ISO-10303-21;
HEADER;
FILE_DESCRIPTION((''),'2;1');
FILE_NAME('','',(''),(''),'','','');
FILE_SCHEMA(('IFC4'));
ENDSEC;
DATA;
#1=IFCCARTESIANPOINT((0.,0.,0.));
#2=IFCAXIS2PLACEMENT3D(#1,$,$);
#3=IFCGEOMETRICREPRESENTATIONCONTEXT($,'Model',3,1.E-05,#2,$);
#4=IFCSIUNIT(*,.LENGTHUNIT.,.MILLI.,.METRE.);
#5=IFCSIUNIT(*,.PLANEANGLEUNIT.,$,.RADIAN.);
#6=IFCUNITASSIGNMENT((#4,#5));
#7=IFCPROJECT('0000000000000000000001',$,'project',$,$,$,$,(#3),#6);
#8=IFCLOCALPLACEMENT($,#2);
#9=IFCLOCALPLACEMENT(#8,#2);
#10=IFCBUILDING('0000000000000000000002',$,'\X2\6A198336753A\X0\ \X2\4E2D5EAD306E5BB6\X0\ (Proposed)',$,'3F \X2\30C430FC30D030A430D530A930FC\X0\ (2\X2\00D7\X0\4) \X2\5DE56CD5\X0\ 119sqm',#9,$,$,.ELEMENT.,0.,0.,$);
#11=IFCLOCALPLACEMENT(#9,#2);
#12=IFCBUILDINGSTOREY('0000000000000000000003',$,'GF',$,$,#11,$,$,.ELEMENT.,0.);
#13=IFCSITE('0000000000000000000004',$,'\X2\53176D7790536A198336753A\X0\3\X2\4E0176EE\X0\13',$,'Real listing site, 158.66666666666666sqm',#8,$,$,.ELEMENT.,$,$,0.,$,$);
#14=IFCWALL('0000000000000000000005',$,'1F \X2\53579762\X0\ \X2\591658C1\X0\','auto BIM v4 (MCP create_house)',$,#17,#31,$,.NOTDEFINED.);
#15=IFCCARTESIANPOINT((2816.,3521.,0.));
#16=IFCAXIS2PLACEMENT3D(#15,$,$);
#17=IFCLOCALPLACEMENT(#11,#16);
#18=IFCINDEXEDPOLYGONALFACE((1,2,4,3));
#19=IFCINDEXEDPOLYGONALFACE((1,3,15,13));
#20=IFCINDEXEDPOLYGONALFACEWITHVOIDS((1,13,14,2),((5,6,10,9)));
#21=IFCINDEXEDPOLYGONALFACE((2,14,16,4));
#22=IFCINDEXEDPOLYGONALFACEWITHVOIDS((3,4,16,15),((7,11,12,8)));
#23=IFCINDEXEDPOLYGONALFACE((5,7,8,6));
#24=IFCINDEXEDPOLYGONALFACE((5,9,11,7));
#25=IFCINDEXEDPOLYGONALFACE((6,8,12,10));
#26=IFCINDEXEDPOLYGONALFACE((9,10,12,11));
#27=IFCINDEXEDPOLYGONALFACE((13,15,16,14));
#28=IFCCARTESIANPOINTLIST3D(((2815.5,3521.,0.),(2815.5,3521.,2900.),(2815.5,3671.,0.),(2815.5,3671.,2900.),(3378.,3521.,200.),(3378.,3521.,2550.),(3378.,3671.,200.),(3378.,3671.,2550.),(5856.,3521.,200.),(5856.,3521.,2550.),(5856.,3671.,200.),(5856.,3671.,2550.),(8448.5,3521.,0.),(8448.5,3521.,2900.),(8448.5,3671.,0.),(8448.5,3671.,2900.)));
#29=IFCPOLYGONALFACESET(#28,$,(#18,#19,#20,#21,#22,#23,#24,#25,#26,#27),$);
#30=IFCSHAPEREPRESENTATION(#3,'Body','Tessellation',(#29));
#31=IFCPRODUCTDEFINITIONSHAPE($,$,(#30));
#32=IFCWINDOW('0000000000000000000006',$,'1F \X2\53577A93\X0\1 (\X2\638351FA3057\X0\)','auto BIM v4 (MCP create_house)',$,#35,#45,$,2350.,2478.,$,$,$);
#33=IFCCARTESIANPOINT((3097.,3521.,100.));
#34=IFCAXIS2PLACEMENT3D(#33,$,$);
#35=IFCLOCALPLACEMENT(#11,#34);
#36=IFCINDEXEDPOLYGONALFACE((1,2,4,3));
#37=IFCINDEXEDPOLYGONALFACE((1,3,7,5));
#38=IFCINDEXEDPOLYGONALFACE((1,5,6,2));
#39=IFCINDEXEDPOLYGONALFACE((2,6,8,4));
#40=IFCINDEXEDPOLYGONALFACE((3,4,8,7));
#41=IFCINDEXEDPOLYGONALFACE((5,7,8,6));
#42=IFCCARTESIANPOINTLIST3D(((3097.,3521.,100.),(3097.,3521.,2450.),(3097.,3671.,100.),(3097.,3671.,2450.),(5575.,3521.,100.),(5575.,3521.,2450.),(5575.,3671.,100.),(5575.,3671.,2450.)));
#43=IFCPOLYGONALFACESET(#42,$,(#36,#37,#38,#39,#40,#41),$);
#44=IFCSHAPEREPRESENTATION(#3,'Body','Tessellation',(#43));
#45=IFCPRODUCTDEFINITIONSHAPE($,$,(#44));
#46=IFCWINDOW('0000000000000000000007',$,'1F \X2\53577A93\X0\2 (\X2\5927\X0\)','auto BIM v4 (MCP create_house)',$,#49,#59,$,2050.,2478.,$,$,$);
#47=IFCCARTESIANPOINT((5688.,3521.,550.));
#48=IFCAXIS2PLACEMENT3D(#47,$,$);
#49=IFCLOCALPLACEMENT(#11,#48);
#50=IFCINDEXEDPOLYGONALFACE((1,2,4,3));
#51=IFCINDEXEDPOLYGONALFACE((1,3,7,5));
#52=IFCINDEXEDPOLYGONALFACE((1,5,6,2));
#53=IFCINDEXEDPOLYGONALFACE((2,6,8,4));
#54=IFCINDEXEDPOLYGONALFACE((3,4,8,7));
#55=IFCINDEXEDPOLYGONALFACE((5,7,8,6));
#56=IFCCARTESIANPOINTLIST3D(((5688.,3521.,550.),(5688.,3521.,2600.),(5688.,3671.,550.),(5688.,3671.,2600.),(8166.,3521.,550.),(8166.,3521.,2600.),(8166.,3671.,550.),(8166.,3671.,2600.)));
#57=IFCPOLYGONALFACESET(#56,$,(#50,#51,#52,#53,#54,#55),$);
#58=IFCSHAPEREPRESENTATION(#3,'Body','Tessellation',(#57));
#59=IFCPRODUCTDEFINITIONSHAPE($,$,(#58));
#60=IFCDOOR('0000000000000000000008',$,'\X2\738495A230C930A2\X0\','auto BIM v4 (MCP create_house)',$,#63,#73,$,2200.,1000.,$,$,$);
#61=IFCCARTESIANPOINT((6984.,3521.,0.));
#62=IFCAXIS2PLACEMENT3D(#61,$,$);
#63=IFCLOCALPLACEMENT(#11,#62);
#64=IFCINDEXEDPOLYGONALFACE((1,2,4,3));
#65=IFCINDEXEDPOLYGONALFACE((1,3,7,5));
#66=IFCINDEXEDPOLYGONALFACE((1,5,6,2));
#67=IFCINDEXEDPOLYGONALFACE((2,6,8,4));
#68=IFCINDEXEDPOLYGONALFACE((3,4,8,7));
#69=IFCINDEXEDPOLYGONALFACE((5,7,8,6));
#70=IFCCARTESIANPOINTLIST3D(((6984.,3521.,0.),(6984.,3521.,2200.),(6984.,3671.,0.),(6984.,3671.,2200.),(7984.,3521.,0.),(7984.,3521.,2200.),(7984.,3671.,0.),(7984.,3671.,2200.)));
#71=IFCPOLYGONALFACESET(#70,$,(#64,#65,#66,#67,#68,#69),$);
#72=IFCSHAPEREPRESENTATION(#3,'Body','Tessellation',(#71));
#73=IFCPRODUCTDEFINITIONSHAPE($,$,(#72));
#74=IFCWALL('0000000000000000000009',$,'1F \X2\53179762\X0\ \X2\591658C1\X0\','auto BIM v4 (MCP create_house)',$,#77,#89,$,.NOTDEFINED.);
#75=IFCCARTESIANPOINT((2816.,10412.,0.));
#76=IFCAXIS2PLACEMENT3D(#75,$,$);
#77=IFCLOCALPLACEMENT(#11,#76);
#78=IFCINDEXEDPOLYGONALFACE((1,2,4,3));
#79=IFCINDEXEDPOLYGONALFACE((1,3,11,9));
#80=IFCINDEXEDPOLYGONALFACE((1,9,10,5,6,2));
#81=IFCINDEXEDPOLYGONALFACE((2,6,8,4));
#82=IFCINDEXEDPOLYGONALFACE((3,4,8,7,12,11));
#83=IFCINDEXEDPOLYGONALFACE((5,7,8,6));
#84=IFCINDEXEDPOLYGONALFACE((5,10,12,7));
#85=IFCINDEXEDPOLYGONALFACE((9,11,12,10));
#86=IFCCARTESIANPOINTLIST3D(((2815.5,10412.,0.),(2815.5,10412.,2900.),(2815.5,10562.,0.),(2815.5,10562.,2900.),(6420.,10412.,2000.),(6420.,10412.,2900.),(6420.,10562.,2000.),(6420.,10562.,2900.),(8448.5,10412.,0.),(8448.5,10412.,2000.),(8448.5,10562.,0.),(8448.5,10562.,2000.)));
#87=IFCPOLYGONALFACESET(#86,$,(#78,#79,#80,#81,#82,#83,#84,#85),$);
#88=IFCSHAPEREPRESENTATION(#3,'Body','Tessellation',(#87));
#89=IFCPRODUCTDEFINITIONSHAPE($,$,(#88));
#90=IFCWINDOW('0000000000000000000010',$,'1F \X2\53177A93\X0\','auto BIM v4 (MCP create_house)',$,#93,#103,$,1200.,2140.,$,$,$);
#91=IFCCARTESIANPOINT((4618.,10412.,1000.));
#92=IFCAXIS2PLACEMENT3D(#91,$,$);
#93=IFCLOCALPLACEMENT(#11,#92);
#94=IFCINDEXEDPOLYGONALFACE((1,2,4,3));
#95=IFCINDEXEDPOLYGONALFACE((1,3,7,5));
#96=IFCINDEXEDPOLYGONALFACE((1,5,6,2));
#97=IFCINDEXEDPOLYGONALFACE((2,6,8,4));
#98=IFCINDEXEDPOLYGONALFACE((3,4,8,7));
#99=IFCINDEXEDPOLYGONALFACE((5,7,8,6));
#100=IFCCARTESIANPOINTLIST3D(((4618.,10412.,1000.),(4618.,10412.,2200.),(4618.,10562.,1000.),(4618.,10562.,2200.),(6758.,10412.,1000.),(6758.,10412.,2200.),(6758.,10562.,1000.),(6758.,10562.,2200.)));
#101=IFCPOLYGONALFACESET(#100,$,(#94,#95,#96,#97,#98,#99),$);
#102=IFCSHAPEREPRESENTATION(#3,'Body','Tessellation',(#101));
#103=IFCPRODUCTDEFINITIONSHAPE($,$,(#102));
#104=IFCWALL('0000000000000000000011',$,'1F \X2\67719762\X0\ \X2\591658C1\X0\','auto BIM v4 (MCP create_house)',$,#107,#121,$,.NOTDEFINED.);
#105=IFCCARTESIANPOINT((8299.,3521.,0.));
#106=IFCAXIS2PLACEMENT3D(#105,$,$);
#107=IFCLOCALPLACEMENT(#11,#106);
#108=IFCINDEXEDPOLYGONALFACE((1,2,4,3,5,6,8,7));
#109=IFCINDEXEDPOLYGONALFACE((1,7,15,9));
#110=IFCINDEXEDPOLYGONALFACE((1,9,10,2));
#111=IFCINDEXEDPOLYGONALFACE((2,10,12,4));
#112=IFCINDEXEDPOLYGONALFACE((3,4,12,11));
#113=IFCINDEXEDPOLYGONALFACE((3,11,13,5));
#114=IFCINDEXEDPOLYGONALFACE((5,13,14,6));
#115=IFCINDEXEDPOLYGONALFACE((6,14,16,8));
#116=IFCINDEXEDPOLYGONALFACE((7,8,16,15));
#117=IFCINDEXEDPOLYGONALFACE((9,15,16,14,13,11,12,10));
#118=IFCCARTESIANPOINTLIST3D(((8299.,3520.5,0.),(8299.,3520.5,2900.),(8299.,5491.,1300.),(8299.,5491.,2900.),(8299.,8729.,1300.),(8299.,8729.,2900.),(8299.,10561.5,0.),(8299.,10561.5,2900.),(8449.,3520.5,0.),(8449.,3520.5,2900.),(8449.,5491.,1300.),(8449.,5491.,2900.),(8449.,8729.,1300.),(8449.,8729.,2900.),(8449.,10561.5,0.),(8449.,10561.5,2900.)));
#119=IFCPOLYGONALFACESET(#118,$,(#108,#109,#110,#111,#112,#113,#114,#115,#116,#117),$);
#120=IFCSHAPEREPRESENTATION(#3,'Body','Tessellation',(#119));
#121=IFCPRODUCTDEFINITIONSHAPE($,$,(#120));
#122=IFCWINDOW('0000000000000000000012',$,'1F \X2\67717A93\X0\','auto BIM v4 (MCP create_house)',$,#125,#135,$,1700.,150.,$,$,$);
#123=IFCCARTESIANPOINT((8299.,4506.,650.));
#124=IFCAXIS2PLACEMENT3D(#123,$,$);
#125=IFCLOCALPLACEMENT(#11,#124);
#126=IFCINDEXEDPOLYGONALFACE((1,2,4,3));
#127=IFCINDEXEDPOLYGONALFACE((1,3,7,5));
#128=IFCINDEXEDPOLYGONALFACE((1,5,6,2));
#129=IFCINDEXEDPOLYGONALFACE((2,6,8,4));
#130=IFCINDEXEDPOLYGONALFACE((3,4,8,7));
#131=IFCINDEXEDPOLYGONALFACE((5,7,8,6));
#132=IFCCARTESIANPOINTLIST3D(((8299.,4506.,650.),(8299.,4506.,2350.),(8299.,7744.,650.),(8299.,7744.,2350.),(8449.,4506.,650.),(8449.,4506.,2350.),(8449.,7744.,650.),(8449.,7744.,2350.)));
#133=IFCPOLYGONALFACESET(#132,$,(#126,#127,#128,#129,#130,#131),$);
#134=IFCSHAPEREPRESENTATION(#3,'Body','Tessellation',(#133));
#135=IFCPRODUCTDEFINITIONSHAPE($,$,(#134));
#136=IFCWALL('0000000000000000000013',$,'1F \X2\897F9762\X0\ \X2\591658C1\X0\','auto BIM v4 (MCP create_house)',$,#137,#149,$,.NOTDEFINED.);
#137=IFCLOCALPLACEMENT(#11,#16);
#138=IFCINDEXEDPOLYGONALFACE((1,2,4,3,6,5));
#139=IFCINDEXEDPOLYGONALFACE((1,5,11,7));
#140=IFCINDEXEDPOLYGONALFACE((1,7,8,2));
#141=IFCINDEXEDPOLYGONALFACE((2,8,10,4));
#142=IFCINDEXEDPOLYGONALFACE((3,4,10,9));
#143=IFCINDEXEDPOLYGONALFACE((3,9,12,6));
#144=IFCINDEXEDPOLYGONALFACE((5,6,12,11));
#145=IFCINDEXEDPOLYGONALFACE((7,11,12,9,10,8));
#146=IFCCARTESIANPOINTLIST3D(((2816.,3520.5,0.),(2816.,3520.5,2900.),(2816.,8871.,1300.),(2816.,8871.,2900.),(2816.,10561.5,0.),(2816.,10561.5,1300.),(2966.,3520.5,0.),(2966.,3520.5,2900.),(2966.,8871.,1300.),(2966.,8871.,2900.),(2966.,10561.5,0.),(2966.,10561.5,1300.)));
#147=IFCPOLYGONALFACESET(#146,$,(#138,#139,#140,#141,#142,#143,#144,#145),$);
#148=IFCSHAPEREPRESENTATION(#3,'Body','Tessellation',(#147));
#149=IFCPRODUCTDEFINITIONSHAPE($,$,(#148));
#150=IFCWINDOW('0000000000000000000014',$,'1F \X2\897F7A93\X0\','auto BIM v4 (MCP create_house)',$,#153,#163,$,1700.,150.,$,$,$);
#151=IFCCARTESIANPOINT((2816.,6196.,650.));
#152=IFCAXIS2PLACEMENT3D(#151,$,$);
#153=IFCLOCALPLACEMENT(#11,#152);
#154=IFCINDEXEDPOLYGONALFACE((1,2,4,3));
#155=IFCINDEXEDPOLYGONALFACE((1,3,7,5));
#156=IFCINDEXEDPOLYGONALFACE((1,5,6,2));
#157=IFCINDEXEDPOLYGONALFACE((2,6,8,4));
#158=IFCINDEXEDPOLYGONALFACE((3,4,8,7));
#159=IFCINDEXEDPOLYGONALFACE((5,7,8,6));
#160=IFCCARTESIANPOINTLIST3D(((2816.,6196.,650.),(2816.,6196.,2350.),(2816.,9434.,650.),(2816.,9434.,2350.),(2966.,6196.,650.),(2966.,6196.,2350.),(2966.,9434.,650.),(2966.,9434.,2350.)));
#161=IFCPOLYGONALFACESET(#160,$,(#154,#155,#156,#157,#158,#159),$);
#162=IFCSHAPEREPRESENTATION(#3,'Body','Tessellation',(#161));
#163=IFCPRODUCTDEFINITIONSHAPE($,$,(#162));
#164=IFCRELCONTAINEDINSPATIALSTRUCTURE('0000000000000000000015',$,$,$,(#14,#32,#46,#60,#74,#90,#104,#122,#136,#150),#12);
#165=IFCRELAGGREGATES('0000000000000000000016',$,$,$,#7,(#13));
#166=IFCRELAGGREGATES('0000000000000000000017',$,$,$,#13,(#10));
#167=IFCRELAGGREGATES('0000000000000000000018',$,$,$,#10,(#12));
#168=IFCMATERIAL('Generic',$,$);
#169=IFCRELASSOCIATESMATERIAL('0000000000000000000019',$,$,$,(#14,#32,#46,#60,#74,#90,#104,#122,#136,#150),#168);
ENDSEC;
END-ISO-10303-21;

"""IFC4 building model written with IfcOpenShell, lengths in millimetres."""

from ifc_helpers import new_model, si_unit, frame, frame_2d, origin, place, context, project, spatial, rectangle, extrude, material, element, fill, save


model = new_model("IFC4")

# Units and contexts
model_context = context("Model", 3, precision=1e-05, world=origin())
ifc_project = project(units=[si_unit("LENGTHUNIT", "METRE", prefix="MILLI"), si_unit("PLANEANGLEUNIT", "RADIAN")], contexts=[model_context])

# Site, building, storey
site_placement = place(None, origin())
site = spatial("IfcSite", under=ifc_project, at=site_placement, Name="北海道標茶町3丁目13", ObjectType="Real listing site, 158.66666666666666sqm", CompositionType="ELEMENT", RefElevation=0.0)
building_placement = place(site_placement, origin())
building = spatial("IfcBuilding", under=site, at=building_placement, Name="標茶町 中庭の家 (Proposed)", ObjectType="3F ツーバイフォー (2×4) 工法 119sqm", CompositionType="ELEMENT", ElevationOfRefHeight=0.0, ElevationOfTerrain=0.0)
storey_placement = place(building_placement, origin())
storey = spatial("IfcBuildingStorey", under=building, at=storey_placement, Name="GF", CompositionType="ELEMENT", Elevation=0.0)

# Shared definitions
ifc_material = material(Name="Generic")

# Wall, openings, windows, door
wall_1_placement = place(storey_placement, frame((2816.0, 3521.0, 0.0)))
wall_1 = element("IfcWall", 1, at=wall_1_placement, inside=storey, material=ifc_material, Name="1F 南面 外壁", Description="auto BIM v4 (MCP create_house)", PredefinedType="NOTDEFINED", context=model_context, shape_type="SweptSolid", body=[
    extrude(rectangle(XDim=5633.0, YDim=150.0, at=frame_2d((2816.0, 75.0))), frame((2816.0, 3521.0, 0.0)), (0.0, 0.0, 1.0), 2900.0),
])
opening_1_placement = place(storey_placement, frame((3097.0, 3521.0, 100.0)))
opening_1 = element("IfcOpeningElement", 2, at=opening_1_placement, cuts=wall_1, PredefinedType="NOTDEFINED", context=model_context, shape_type="SweptSolid", body=[
    extrude(rectangle(XDim=2478.0, YDim=150.0, at=frame_2d((1239.0, 75.0))), frame((3097.0, 3521.0, 100.0)), (0.0, 0.0, 1.0), 2350.0),
])
opening_2_placement = place(storey_placement, frame((5688.0, 3521.0, 550.0)))
opening_2 = element("IfcOpeningElement", 3, at=opening_2_placement, cuts=wall_1, PredefinedType="NOTDEFINED", context=model_context, shape_type="SweptSolid", body=[
    extrude(rectangle(XDim=2478.0, YDim=150.0, at=frame_2d((1239.0, 75.0))), frame((5688.0, 3521.0, 550.0)), (0.0, 0.0, 1.0), 2050.0),
])
opening_3_placement = place(storey_placement, frame((6984.0, 3521.0, 0.0)))
opening_3 = element("IfcOpeningElement", 4, at=opening_3_placement, cuts=wall_1, PredefinedType="NOTDEFINED", context=model_context, shape_type="SweptSolid", body=[
    extrude(rectangle(XDim=1000.0, YDim=150.0, at=frame_2d((500.0, 75.0))), frame((6984.0, 3521.0, 0.0)), (0.0, 0.0, 1.0), 2200.0),
])
window_1_placement = place(storey_placement, frame((3097.0, 3521.0, 100.0)))
window_1 = element("IfcWindow", 5, at=window_1_placement, inside=storey, material=ifc_material, Name="1F 南窓1 (掃出し)", Description="auto BIM v4 (MCP create_house)", OverallHeight=2350.0, OverallWidth=2478.0, context=model_context, shape_type="SweptSolid", body=[
    extrude(rectangle(XDim=2478.0, YDim=150.0, at=frame_2d((1239.0, 75.0))), frame((3097.0, 3521.0, 100.0)), (0.0, 0.0, 1.0), 2350.0),
])
fill(opening_1, window_1)
window_2_placement = place(storey_placement, frame((5688.0, 3521.0, 550.0)))
window_2 = element("IfcWindow", 6, at=window_2_placement, inside=storey, material=ifc_material, Name="1F 南窓2 (大)", Description="auto BIM v4 (MCP create_house)", OverallHeight=2050.0, OverallWidth=2478.0, context=model_context, shape_type="SweptSolid", body=[
    extrude(rectangle(XDim=2478.0, YDim=150.0, at=frame_2d((1239.0, 75.0))), frame((5688.0, 3521.0, 550.0)), (0.0, 0.0, 1.0), 2050.0),
])
fill(opening_2, window_2)
door_placement = place(storey_placement, frame((6984.0, 3521.0, 0.0)))
door = element("IfcDoor", 7, at=door_placement, inside=storey, material=ifc_material, Name="玄関ドア", Description="auto BIM v4 (MCP create_house)", OverallHeight=2200.0, OverallWidth=1000.0, context=model_context, shape_type="SweptSolid", body=[
    extrude(rectangle(XDim=1000.0, YDim=150.0, at=frame_2d((500.0, 75.0))), frame((6984.0, 3521.0, 0.0)), (0.0, 0.0, 1.0), 2200.0),
])
fill(opening_3, door)

# Walls, openings, windows
wall_2_placement = place(storey_placement, frame((2816.0, 10412.0, 0.0)))
wall_2 = element("IfcWall", 8, at=wall_2_placement, inside=storey, material=ifc_material, Name="1F 北面 外壁", Description="auto BIM v4 (MCP create_house)", PredefinedType="NOTDEFINED", context=model_context, shape_type="SweptSolid", body=[
    extrude(rectangle(XDim=5633.0, YDim=150.0, at=frame_2d((2816.0, 75.0))), frame((2816.0, 10412.0, 0.0)), (0.0, 0.0, 1.0), 2900.0),
])
opening_4_placement = place(storey_placement, frame((4618.0, 10412.0, 1000.0)))
opening_4 = element("IfcOpeningElement", 9, at=opening_4_placement, cuts=wall_2, PredefinedType="NOTDEFINED", context=model_context, shape_type="SweptSolid", body=[
    extrude(rectangle(XDim=2140.0, YDim=150.0, at=frame_2d((1070.0, 75.0))), frame((4618.0, 10412.0, 1000.0)), (0.0, 0.0, 1.0), 1200.0),
])
window_3_placement = place(storey_placement, frame((4618.0, 10412.0, 1000.0)))
window_3 = element("IfcWindow", 10, at=window_3_placement, inside=storey, material=ifc_material, Name="1F 北窓", Description="auto BIM v4 (MCP create_house)", OverallHeight=1200.0, OverallWidth=2140.0, context=model_context, shape_type="SweptSolid", body=[
    extrude(rectangle(XDim=2140.0, YDim=150.0, at=frame_2d((1070.0, 75.0))), frame((4618.0, 10412.0, 1000.0)), (0.0, 0.0, 1.0), 1200.0),
])
fill(opening_4, window_3)
wall_3_placement = place(storey_placement, frame((8299.0, 3521.0, 0.0)))
wall_3 = element("IfcWall", 11, at=wall_3_placement, inside=storey, material=ifc_material, Name="1F 東面 外壁", Description="auto BIM v4 (MCP create_house)", PredefinedType="NOTDEFINED", context=model_context, shape_type="SweptSolid", body=[
    extrude(rectangle(XDim=150.0, YDim=7041.0, at=frame_2d((75.0, 3520.0))), frame((8299.0, 3521.0, 0.0)), (0.0, 0.0, 1.0), 2900.0),
])
opening_5_placement = place(storey_placement, frame((8299.0, 4506.0, 650.0)))
opening_5 = element("IfcOpeningElement", 12, at=opening_5_placement, cuts=wall_3, PredefinedType="NOTDEFINED", context=model_context, shape_type="SweptSolid", body=[
    extrude(rectangle(XDim=150.0, YDim=3238.0, at=frame_2d((75.0, 1619.0))), frame((8299.0, 4506.0, 650.0)), (0.0, 0.0, 1.0), 1700.0),
])
window_4_placement = place(storey_placement, frame((8299.0, 4506.0, 650.0)))
window_4 = element("IfcWindow", 13, at=window_4_placement, inside=storey, material=ifc_material, Name="1F 東窓", Description="auto BIM v4 (MCP create_house)", OverallHeight=1700.0, OverallWidth=150.0, context=model_context, shape_type="SweptSolid", body=[
    extrude(rectangle(XDim=150.0, YDim=3238.0, at=frame_2d((75.0, 1619.0))), frame((8299.0, 4506.0, 650.0)), (0.0, 0.0, 1.0), 1700.0),
])
fill(opening_5, window_4)
wall_4_placement = place(storey_placement, frame((2816.0, 3521.0, 0.0)))
wall_4 = element("IfcWall", 14, at=wall_4_placement, inside=storey, material=ifc_material, Name="1F 西面 外壁", Description="auto BIM v4 (MCP create_house)", PredefinedType="NOTDEFINED", context=model_context, shape_type="SweptSolid", body=[
    extrude(rectangle(XDim=150.0, YDim=7041.0, at=frame_2d((75.0, 3520.0))), frame((2816.0, 3521.0, 0.0)), (0.0, 0.0, 1.0), 2900.0),
])
opening_6_placement = place(storey_placement, frame((2816.0, 6196.0, 650.0)))
opening_6 = element("IfcOpeningElement", 15, at=opening_6_placement, cuts=wall_4, PredefinedType="NOTDEFINED", context=model_context, shape_type="SweptSolid", body=[
    extrude(rectangle(XDim=150.0, YDim=3238.0, at=frame_2d((75.0, 1619.0))), frame((2816.0, 6196.0, 650.0)), (0.0, 0.0, 1.0), 1700.0),
])
window_5_placement = place(storey_placement, frame((2816.0, 6196.0, 650.0)))
window_5 = element("IfcWindow", 16, at=window_5_placement, inside=storey, material=ifc_material, Name="1F 西窓", Description="auto BIM v4 (MCP create_house)", OverallHeight=1700.0, OverallWidth=150.0, context=model_context, shape_type="SweptSolid", body=[
    extrude(rectangle(XDim=150.0, YDim=3238.0, at=frame_2d((75.0, 1619.0))), frame((2816.0, 6196.0, 650.0)), (0.0, 0.0, 1.0), 1700.0),
])
fill(opening_6, window_5)

save(model, "model.ifc")
